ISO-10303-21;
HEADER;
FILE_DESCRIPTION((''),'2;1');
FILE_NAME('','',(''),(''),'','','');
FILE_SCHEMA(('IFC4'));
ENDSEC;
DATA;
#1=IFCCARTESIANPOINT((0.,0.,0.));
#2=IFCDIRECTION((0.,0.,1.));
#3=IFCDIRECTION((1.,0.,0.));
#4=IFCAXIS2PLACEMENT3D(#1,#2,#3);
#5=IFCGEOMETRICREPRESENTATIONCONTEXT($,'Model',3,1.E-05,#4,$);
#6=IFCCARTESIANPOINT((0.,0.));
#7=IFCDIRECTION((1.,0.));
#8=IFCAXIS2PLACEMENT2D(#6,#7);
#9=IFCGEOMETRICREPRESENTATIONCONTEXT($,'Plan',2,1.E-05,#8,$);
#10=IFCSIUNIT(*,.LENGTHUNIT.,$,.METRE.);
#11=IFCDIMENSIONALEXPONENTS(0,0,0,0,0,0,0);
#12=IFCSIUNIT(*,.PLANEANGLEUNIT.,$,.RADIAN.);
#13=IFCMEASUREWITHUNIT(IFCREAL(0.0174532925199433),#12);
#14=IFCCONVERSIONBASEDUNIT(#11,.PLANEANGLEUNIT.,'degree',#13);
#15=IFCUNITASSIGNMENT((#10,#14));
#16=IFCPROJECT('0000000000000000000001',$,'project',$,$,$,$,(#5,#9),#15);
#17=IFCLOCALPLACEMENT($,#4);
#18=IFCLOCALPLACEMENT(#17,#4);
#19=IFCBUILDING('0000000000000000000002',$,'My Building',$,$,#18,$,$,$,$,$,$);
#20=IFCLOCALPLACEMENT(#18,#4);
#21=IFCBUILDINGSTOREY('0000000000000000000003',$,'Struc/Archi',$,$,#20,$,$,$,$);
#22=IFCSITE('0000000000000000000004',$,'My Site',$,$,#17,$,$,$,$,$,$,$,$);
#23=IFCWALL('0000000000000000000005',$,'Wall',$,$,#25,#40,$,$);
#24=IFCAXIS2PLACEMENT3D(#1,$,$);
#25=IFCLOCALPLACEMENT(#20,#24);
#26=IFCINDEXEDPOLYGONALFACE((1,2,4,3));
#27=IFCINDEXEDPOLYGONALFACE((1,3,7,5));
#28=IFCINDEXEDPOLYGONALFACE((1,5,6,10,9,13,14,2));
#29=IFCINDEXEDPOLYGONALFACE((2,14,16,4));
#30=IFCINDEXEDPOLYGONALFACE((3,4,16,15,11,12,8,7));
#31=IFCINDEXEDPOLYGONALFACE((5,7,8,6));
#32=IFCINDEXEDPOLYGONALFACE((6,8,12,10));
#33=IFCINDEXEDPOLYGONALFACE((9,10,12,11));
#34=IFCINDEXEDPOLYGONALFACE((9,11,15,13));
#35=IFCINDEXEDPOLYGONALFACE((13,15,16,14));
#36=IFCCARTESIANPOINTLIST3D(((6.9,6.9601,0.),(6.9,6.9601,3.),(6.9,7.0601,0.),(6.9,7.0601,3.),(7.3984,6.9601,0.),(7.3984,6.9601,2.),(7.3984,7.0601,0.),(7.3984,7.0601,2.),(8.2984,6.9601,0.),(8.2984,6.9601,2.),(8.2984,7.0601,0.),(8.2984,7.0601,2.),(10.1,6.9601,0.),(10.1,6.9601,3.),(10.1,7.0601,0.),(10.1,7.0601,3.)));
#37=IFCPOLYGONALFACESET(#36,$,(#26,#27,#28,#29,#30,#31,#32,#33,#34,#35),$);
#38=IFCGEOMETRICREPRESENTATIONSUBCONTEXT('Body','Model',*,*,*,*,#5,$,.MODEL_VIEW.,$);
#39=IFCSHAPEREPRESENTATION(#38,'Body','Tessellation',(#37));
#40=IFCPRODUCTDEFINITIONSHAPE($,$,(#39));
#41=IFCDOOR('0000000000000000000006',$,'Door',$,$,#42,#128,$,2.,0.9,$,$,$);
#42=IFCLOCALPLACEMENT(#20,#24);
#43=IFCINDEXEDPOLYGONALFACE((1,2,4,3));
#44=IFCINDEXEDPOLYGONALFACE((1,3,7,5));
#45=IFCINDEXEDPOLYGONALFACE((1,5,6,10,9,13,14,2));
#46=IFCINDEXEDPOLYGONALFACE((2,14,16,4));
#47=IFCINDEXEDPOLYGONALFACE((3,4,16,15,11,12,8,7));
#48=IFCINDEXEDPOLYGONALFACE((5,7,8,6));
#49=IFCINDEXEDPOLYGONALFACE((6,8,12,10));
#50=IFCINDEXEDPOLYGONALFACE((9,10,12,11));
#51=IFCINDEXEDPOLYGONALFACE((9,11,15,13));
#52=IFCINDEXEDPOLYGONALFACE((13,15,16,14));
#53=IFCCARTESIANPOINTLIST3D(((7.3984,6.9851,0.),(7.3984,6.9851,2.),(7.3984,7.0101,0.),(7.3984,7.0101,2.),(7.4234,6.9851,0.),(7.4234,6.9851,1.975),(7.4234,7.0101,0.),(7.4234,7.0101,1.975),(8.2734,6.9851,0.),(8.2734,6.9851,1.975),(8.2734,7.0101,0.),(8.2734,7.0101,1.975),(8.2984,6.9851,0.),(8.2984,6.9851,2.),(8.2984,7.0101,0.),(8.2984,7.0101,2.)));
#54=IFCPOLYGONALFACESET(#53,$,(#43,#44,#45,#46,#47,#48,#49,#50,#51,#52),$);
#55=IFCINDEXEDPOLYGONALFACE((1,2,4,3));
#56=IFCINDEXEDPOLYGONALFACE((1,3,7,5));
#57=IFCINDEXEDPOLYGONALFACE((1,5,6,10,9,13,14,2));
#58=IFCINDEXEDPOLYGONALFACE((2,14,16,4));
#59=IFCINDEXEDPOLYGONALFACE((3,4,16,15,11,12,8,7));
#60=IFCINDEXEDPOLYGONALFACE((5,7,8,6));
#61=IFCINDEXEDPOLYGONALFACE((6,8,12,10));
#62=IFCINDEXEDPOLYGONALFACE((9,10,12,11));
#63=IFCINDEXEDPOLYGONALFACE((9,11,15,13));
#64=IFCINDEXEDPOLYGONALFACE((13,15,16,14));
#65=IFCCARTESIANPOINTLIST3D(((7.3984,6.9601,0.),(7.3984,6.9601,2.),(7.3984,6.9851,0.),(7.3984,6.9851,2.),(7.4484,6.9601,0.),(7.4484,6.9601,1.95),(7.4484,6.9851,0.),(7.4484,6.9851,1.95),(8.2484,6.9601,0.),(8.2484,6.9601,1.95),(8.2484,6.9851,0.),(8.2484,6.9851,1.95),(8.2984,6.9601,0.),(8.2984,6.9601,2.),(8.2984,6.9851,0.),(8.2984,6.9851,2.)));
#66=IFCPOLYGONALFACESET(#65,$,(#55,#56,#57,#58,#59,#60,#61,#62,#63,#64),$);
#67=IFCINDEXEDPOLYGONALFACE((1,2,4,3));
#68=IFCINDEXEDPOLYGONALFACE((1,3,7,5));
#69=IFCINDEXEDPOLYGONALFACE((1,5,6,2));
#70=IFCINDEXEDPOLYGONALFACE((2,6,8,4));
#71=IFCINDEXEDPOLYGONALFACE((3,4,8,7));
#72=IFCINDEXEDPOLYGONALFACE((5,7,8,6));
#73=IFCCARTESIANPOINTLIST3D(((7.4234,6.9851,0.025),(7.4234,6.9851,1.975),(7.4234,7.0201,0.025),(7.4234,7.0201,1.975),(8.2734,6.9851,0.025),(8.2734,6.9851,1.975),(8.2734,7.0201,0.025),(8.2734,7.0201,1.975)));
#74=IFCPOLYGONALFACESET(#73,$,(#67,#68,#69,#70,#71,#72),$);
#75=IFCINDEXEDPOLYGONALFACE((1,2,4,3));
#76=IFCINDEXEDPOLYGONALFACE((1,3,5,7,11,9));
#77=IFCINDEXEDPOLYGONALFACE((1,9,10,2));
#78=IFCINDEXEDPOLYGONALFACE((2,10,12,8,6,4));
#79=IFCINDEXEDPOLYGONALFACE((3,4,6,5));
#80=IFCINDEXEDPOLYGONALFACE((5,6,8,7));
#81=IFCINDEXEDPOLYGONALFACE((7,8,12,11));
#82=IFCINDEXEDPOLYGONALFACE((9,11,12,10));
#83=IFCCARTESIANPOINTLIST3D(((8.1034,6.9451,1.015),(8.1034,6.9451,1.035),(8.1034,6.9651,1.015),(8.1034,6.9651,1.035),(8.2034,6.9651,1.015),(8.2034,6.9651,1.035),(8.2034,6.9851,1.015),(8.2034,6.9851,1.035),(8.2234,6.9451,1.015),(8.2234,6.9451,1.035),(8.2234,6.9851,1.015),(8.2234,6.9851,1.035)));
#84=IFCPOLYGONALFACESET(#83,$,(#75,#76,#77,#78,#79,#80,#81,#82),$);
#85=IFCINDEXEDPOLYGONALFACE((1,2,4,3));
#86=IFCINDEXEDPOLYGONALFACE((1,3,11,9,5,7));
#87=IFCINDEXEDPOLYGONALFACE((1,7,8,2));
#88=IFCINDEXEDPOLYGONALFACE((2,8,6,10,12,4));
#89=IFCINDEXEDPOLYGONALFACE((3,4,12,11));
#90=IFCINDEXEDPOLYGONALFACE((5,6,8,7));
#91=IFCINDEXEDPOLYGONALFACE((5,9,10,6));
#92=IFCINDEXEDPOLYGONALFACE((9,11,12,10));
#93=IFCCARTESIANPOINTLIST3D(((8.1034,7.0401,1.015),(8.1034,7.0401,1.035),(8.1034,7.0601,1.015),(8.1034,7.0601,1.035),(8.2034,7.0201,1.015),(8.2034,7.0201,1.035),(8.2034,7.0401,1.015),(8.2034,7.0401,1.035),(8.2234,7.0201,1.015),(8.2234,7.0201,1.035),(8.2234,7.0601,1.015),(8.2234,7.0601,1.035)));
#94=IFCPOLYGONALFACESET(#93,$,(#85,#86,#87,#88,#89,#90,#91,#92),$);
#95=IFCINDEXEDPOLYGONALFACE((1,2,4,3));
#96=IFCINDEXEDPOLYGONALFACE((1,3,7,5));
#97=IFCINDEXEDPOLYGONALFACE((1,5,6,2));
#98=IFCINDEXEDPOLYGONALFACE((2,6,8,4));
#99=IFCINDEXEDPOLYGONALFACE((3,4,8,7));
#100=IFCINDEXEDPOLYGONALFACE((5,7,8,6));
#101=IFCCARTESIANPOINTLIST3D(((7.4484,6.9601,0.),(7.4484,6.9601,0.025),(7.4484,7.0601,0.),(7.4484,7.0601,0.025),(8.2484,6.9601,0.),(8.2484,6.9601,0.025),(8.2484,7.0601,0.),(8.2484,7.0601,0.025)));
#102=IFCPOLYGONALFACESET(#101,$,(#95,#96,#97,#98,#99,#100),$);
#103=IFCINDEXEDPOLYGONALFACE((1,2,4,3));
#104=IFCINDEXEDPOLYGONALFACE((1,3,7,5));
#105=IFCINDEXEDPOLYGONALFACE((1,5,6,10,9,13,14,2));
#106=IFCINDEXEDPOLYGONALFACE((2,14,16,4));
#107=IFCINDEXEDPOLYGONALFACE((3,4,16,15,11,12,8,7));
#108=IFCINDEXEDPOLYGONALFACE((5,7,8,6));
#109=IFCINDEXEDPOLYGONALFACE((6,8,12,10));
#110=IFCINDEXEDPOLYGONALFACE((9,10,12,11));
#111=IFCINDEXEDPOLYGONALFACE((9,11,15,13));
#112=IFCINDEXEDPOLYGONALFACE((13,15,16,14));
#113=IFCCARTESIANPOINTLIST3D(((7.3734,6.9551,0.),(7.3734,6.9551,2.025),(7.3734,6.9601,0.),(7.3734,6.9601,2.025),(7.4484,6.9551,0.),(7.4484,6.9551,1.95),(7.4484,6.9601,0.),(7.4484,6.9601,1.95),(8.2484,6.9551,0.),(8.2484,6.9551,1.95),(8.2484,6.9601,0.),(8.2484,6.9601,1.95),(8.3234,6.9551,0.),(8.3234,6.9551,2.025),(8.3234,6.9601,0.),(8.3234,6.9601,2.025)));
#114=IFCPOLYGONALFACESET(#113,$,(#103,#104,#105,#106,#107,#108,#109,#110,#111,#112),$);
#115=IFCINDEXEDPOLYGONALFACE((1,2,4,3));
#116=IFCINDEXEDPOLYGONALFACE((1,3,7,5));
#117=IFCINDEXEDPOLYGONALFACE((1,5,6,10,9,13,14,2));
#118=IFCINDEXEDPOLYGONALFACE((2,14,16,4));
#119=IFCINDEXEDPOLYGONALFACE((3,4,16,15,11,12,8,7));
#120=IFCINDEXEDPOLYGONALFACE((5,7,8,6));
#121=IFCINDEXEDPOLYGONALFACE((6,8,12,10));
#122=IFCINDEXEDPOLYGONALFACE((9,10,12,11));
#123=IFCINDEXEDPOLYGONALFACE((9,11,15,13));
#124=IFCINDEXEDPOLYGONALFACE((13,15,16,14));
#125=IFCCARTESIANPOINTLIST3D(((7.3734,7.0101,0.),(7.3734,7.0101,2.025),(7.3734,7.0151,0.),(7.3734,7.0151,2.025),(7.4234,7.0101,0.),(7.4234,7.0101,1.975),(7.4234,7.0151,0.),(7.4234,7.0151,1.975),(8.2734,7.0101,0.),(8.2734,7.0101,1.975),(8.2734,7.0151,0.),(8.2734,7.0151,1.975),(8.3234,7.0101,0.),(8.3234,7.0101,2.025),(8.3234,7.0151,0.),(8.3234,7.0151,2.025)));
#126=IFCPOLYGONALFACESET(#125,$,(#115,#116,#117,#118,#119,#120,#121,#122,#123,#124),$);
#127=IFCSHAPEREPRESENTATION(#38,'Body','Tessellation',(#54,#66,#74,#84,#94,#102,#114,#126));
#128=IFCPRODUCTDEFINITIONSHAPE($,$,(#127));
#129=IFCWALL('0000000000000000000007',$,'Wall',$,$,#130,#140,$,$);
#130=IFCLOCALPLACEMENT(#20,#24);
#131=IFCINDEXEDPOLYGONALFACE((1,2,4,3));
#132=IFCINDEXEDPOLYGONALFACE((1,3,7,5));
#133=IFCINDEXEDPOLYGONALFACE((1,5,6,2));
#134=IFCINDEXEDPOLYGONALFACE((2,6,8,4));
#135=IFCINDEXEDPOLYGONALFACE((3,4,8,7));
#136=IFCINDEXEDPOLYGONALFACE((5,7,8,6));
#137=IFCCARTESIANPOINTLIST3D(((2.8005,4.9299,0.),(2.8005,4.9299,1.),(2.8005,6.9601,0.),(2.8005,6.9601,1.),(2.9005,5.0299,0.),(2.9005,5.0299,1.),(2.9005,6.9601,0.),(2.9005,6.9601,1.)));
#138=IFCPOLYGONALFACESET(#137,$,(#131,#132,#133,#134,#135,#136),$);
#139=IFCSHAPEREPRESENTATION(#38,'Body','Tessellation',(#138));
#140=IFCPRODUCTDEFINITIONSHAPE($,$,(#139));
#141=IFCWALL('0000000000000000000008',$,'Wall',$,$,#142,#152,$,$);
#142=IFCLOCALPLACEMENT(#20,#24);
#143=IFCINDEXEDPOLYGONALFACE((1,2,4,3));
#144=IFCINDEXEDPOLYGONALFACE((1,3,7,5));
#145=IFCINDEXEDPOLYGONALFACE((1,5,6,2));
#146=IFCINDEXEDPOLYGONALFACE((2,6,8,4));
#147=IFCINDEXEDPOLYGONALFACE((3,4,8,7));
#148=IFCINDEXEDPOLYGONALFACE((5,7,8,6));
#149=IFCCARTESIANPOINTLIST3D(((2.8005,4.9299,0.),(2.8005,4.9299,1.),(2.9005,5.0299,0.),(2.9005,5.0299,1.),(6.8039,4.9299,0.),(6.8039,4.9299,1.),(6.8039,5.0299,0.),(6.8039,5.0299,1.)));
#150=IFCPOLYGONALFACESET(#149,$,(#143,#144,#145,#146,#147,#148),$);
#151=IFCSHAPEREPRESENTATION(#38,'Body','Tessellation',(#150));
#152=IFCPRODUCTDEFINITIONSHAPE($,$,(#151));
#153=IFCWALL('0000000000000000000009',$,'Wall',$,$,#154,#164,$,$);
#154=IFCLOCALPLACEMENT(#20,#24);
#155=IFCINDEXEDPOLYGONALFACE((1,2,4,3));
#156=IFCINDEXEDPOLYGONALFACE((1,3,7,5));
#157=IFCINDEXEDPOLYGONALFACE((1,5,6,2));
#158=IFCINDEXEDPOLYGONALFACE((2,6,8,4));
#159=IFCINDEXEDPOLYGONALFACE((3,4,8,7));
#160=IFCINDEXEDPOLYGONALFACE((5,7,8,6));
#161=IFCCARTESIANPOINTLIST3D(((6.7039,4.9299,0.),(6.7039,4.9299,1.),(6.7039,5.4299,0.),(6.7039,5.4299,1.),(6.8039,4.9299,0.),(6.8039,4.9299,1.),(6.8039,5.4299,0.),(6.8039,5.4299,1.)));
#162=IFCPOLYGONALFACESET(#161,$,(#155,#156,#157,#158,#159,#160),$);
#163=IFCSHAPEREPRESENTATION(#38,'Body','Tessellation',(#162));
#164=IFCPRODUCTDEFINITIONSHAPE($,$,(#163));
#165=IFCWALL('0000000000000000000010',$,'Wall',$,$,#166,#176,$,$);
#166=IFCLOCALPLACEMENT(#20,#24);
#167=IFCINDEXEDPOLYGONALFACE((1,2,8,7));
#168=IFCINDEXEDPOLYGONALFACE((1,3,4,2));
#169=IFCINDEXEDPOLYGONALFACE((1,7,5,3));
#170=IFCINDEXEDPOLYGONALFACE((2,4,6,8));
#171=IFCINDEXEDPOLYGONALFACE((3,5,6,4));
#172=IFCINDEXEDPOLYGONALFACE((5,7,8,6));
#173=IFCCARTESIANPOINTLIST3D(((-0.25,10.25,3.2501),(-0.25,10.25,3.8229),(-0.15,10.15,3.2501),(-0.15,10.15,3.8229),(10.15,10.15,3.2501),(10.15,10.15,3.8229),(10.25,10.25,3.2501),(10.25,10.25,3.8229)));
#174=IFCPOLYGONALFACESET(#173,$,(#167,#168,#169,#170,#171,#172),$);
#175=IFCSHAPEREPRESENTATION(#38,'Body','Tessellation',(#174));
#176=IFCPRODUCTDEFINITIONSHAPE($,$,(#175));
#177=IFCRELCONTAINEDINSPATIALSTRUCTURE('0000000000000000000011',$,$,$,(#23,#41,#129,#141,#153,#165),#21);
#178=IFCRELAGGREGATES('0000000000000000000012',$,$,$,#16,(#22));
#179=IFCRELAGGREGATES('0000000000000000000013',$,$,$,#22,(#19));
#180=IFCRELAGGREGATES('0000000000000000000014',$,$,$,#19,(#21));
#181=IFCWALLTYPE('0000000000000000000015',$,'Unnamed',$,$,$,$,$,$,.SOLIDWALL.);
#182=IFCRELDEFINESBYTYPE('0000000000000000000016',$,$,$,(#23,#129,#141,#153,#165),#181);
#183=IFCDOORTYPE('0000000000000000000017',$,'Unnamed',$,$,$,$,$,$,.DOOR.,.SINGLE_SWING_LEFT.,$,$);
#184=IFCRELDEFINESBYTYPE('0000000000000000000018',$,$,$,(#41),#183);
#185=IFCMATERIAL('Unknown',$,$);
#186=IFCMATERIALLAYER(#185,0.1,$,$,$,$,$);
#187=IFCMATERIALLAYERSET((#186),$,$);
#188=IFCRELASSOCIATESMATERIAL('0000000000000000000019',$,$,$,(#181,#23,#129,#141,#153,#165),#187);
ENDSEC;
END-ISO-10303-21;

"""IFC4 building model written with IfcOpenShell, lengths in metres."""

from ifc_helpers import new_model, entity, si_unit, converted_unit, frame, origin_with_axes, origin_2d_with_axis, place, context, subcontext, project, spatial, line, indexed_curve, outline, extrude, shape, source, transform, mapped, material, layer, layer_set, layer_usage, type_object, type_shapes, element, fill, save


model = new_model("IFC4")

# Units and contexts
model_context = context("Model", 3, precision=1e-05, world=origin_with_axes())
plan_context = context("Plan", 2, precision=1e-05, world=origin_2d_with_axis())
body_context_1 = subcontext(model_context, "Body", "Model", "MODEL_VIEW")
body_context_2 = subcontext(plan_context, "Body", "Plan", "PLAN_VIEW")
ifc_project = project(units=[si_unit("LENGTHUNIT", "METRE"), converted_unit("PLANEANGLEUNIT", "degree", entity("IfcReal", 0.0174532925199433), si_unit("PLANEANGLEUNIT", "RADIAN"), dimensions=[0, 0, 0, 0, 0, 0, 0])], contexts=[model_context, plan_context])

# Site, building, storey
site_placement = place(None, origin_with_axes())
site = spatial("IfcSite", under=ifc_project, at=site_placement, Name="My Site")
building_placement = place(site_placement, origin_with_axes())
building = spatial("IfcBuilding", under=site, at=building_placement, Name="My Building")
storey_placement = place(building_placement, origin_with_axes())
storey = spatial("IfcBuildingStorey", under=building, at=storey_placement, Name="Struc/Archi")

# Shared definitions
ifc_material = material(Name="Unknown")

# Shared definitions
ifc_layer_1 = layer(ifc_material, 0.1)
ifc_layer_set_1 = layer_set([ifc_layer_1])
wall_type = type_object("IfcWallType", Name="Unnamed", PredefinedType="SOLIDWALL", material=ifc_layer_set_1)

# Shared definitions
shared_shape_1 = source(origin_with_axes(), body_context_1, "Body", "SweptSolid", [
    extrude(outline(indexed_curve([(0.0, 0.0), (0.9, 0.0), (0.9, 2.0), (0.0, 2.0)], segments=[line(1, 2, 3, 4, 1)])), frame((0.0, -0.6, 0.0), z_axis=(0.0, -1.0, 0.0), x_axis=(1.0, 0.0, 0.0)), (0.0, 0.0, -1.0), 1.2),
])
door_type = type_object("IfcDoorType", Name="Unnamed", OperationType="SINGLE_SWING_LEFT", PredefinedType="DOOR")
shared_shape_2 = source(origin_with_axes(), body_context_1, "Body", "SweptSolid", [
    extrude(outline(indexed_curve([(0.0, 0.0), (0.0, 2.0), (0.9, 2.0), (0.9, 0.0), (0.875, 0.0), (0.875, 1.975), (0.025, 1.975), (0.025, 0.0)], segments=[line(1, 2, 3, 4, 5, 6, 7, 8, 1)])), frame((0.0, 0.025, 0.0), z_axis=(0.0, -1.0, 0.0), x_axis=(1.0, 0.0, 0.0)), (0.0, 0.0, -1.0), 0.025),
    extrude(outline(indexed_curve([(0.0, 0.0), (0.0, 2.0), (0.9, 2.0), (0.9, 0.0), (0.85, 0.0), (0.85, 1.95), (0.05, 1.95), (0.05, 0.0)], segments=[line(1, 2, 3, 4, 5, 6, 7, 8, 1)])), frame((0.0, 0.0, 0.0), z_axis=(0.0, -1.0, 0.0), x_axis=(1.0, 0.0, 0.0)), (0.0, 0.0, -1.0), 0.025),
    extrude(outline(indexed_curve([(0.0, 0.0), (0.85, 0.0), (0.85, 0.035), (0.0, 0.035)], segments=[line(1, 2, 3, 4, 1)])), frame((0.025, 0.025, 0.025), z_axis=(0.0, 0.0, 1.0), x_axis=(1.0, 0.0, 0.0)), (0.0, 0.0, 1.0), 1.95),
    extrude(outline(indexed_curve([(0.0, 0.0), (0.0, -0.04), (-0.12, -0.04), (-0.12, -0.02), (-0.02, -0.02), (-0.02, 0.0)], segments=[line(1, 2, 3, 4, 5, 6, 1)])), frame((0.825, 0.025, 1.015), z_axis=(0.0, 0.0, 1.0), x_axis=(1.0, 0.0, 0.0)), (0.0, 0.0, 1.0), 0.02),
    extrude(outline(indexed_curve([(0.0, 0.0), (0.0, 0.04), (-0.12, 0.04), (-0.12, 0.02), (-0.02, 0.02), (-0.02, 0.0)], segments=[line(1, 2, 3, 4, 5, 6, 1)])), frame((0.825, 0.06, 1.015), z_axis=(0.0, 0.0, 1.0), x_axis=(1.0, 0.0, 0.0)), (0.0, 0.0, 1.0), 0.02),
    extrude(outline(indexed_curve([(0.0, 0.0), (0.8, 0.0), (0.8, 0.1), (0.0, 0.1)], segments=[line(1, 2, 3, 4, 1)])), frame((0.05, 0.0, 0.0), z_axis=(0.0, 0.0, 1.0), x_axis=(1.0, 0.0, 0.0)), (0.0, 0.0, 1.0), 0.025),
    extrude(outline(indexed_curve([(0.0, 0.0), (0.0, 2.025), (0.95, 2.025), (0.95, 0.0), (0.875, 0.0), (0.875, 1.95), (0.075, 1.95), (0.075, 0.0)], segments=[line(1, 2, 3, 4, 5, 6, 7, 8, 1)])), frame((-0.025, -0.005, 0.0), z_axis=(0.0, -1.0, 0.0), x_axis=(1.0, 0.0, 0.0)), (0.0, 0.0, -1.0), 0.005),
    extrude(outline(indexed_curve([(0.0, 0.0), (0.0, 2.025), (0.95, 2.025), (0.95, 0.0), (0.9, 0.0), (0.9, 1.975), (0.05, 1.975), (0.05, 0.0)], segments=[line(1, 2, 3, 4, 5, 6, 7, 8, 1)])), frame((-0.025, 0.05, 0.0), z_axis=(0.0, -1.0, 0.0), x_axis=(1.0, 0.0, 0.0)), (0.0, 0.0, -1.0), 0.005),
])
shared_shape_3 = source(origin_with_axes(), body_context_2, "Body", "Curve2D", [
    entity("IfcIndexedPolyCurve", entity("IfcCartesianPointList2D", [[0.0, 0.0], [0.0, 0.05], [0.025, 0.05], [0.025, 0.025], [0.05, 0.025], [0.05, 0.0]]), [entity("IfcLineIndex", [1, 2, 3, 4, 5, 6, 1])]),
    entity("IfcIndexedPolyCurve", entity("IfcCartesianPointList2D", [[0.9, 0.0], [0.9, 0.05], [0.875, 0.05], [0.875, 0.025], [0.85, 0.025], [0.85, 0.0]]), [entity("IfcLineIndex", [1, 2, 3, 4, 5, 6, 1])]),
    entity("IfcTrimmedCurve", entity("IfcEllipse", entity("IfcAxis2Placement2D", entity("IfcCartesianPoint", [0.06, 0.05]), entity("IfcDirection", [1.0, 0.0])), 0.815, 0.85), [entity("IfcCartesianPoint", [0.875, 0.05])], [entity("IfcCartesianPoint", [0.06, 0.9])], True, "CARTESIAN"),
    entity("IfcIndexedPolyCurve", entity("IfcCartesianPointList2D", [[0.025, 0.05], [0.06, 0.05], [0.06, 0.9], [0.025, 0.9]]), [entity("IfcLineIndex", [1, 2, 3, 4, 1])]),
])
type_shapes(door_type, [shared_shape_2, shared_shape_3])

# Wall, opening, door
ifc_layer_usage_1 = layer_usage(ifc_layer_set_1, "AXIS2", "POSITIVE", 0.0)
wall_1_placement = place(storey_placement, frame((6.9, 6.9601, 0.0), z_axis=(0.0, 0.0, 1.0), x_axis=(1.0, 0.0, 0.0)))
wall_1 = element("IfcWall", 1, at=wall_1_placement, inside=storey, type_object=wall_type, material=ifc_layer_usage_1, Name="Wall", context=body_context_1, shape_type="SweptSolid", body=[
    extrude(outline(indexed_curve([(0.0, 0.0), (0.0, 0.1), (3.2, 0.1), (3.2, 0.0)], segments=[line(1, 2, 3, 4, 1)])), origin_with_axes(), (0.0, 0.0, 1.0), 3.0),
])
opening_1_placement = place(wall_1_placement, frame((0.4984, 0.0, 0.0), z_axis=(0.0, 0.0, 1.0), x_axis=(1.0, 0.0, 0.0)))
opening_1 = element("IfcOpeningElement", 2, at=opening_1_placement, cuts=wall_1, PredefinedType="OPENING", context=body_context_1, shape_type="MappedRepresentation", body=[
    mapped(shared_shape_1, transform((0.0, 0.0, 0.0), x_axis=(1.0, 0.0, 0.0), y_axis=(0.0, 1.0, 0.0), z_axis=(0.0, 0.0, 1.0), scale=1.0)),
])
door_1_placement = place(opening_1_placement, frame((0.0, 0.0, 0.0), z_axis=(0.0, 0.0, 1.0), x_axis=(1.0, 0.0, 0.0)))
door_1 = element("IfcDoor", 3, at=door_1_placement, inside=storey, type_object=door_type, Name="Door", OverallHeight=2.0, OverallWidth=0.9, shapes=[
    shape(body_context_1, "Body", "MappedRepresentation", [mapped(shared_shape_2, transform((0.0, 0.0, 0.0), x_axis=(1.0, 0.0, 0.0), y_axis=(0.0, 1.0, 0.0), z_axis=(0.0, 0.0, 1.0), scale=1.0))]),
    shape(body_context_2, "Body", "MappedRepresentation", [mapped(shared_shape_3, transform((0.0, 0.0, 0.0), x_axis=(1.0, 0.0, 0.0), y_axis=(0.0, 1.0, 0.0), z_axis=(0.0, 0.0, 1.0), scale=1.0))]),
])
fill(opening_1, door_1)

# Walls
ifc_layer_usage_2 = layer_usage(ifc_layer_set_1, "AXIS2", "POSITIVE", 0.0)
wall_2_placement = place(storey_placement, frame((2.8005, 6.9601, 0.0), z_axis=(0.0, 0.0, 1.0), x_axis=(0.0, -1.0, 0.0)))
element("IfcWall", 4, at=wall_2_placement, inside=storey, type_object=wall_type, material=ifc_layer_usage_2, Name="Wall", context=body_context_1, shape_type="SweptSolid", body=[
    extrude(outline(indexed_curve([(0.0, 0.0), (0.0, 0.1), (1.9301, 0.1), (2.0301, 0.0)], segments=[line(1, 2, 3, 4, 1)])), origin_with_axes(), (0.0, 0.0, 1.0), 1.0),
])
ifc_layer_usage_3 = layer_usage(ifc_layer_set_1, "AXIS2", "POSITIVE", 0.0)
wall_3_placement = place(storey_placement, frame((2.8005, 4.9299, 0.0), z_axis=(0.0, 0.0, 1.0), x_axis=(1.0, 0.0, 0.0)))
element("IfcWall", 5, at=wall_3_placement, inside=storey, type_object=wall_type, material=ifc_layer_usage_3, Name="Wall", context=body_context_1, shape_type="SweptSolid", body=[
    extrude(outline(indexed_curve([(0.0, 0.0), (0.1, 0.1), (4.0034, 0.1), (4.0034, 0.0)], segments=[line(1, 2, 3, 4, 1)])), origin_with_axes(), (0.0, 0.0, 1.0), 1.0),
])
ifc_layer_usage_4 = layer_usage(ifc_layer_set_1, "AXIS2", "POSITIVE", 0.0)
wall_4_placement = place(storey_placement, frame((6.7039, 5.4299, 0.0), z_axis=(0.0, 0.0, 1.0), x_axis=(0.0, -1.0, 0.0)))
element("IfcWall", 6, at=wall_4_placement, inside=storey, type_object=wall_type, material=ifc_layer_usage_4, Name="Wall", context=body_context_1, shape_type="SweptSolid", body=[
    extrude(outline(indexed_curve([(0.0, 0.0), (0.0, 0.1), (0.5, 0.1), (0.5, 0.0)], segments=[line(1, 2, 3, 4, 1)])), origin_with_axes(), (0.0, 0.0, 1.0), 1.0),
])
ifc_layer_usage_5 = layer_usage(ifc_layer_set_1, "AXIS2", "POSITIVE", 0.0)
wall_5_placement = place(storey_placement, frame((10.25, 10.25, 3.2501), z_axis=(0.0, 0.0, 1.0), x_axis=(-1.0, 0.0, 0.0)))
element("IfcWall", 7, at=wall_5_placement, inside=storey, type_object=wall_type, material=ifc_layer_usage_5, Name="Wall", context=body_context_1, shape_type="SweptSolid", body=[
    extrude(outline(indexed_curve([(0.0, 0.0), (0.1, 0.1), (10.4, 0.1), (10.5, 0.0)], segments=[line(1, 2, 3, 4, 1)])), origin_with_axes(), (0.0, 0.0, 1.0), 0.5728),
])

save(model, "model.ifc")
